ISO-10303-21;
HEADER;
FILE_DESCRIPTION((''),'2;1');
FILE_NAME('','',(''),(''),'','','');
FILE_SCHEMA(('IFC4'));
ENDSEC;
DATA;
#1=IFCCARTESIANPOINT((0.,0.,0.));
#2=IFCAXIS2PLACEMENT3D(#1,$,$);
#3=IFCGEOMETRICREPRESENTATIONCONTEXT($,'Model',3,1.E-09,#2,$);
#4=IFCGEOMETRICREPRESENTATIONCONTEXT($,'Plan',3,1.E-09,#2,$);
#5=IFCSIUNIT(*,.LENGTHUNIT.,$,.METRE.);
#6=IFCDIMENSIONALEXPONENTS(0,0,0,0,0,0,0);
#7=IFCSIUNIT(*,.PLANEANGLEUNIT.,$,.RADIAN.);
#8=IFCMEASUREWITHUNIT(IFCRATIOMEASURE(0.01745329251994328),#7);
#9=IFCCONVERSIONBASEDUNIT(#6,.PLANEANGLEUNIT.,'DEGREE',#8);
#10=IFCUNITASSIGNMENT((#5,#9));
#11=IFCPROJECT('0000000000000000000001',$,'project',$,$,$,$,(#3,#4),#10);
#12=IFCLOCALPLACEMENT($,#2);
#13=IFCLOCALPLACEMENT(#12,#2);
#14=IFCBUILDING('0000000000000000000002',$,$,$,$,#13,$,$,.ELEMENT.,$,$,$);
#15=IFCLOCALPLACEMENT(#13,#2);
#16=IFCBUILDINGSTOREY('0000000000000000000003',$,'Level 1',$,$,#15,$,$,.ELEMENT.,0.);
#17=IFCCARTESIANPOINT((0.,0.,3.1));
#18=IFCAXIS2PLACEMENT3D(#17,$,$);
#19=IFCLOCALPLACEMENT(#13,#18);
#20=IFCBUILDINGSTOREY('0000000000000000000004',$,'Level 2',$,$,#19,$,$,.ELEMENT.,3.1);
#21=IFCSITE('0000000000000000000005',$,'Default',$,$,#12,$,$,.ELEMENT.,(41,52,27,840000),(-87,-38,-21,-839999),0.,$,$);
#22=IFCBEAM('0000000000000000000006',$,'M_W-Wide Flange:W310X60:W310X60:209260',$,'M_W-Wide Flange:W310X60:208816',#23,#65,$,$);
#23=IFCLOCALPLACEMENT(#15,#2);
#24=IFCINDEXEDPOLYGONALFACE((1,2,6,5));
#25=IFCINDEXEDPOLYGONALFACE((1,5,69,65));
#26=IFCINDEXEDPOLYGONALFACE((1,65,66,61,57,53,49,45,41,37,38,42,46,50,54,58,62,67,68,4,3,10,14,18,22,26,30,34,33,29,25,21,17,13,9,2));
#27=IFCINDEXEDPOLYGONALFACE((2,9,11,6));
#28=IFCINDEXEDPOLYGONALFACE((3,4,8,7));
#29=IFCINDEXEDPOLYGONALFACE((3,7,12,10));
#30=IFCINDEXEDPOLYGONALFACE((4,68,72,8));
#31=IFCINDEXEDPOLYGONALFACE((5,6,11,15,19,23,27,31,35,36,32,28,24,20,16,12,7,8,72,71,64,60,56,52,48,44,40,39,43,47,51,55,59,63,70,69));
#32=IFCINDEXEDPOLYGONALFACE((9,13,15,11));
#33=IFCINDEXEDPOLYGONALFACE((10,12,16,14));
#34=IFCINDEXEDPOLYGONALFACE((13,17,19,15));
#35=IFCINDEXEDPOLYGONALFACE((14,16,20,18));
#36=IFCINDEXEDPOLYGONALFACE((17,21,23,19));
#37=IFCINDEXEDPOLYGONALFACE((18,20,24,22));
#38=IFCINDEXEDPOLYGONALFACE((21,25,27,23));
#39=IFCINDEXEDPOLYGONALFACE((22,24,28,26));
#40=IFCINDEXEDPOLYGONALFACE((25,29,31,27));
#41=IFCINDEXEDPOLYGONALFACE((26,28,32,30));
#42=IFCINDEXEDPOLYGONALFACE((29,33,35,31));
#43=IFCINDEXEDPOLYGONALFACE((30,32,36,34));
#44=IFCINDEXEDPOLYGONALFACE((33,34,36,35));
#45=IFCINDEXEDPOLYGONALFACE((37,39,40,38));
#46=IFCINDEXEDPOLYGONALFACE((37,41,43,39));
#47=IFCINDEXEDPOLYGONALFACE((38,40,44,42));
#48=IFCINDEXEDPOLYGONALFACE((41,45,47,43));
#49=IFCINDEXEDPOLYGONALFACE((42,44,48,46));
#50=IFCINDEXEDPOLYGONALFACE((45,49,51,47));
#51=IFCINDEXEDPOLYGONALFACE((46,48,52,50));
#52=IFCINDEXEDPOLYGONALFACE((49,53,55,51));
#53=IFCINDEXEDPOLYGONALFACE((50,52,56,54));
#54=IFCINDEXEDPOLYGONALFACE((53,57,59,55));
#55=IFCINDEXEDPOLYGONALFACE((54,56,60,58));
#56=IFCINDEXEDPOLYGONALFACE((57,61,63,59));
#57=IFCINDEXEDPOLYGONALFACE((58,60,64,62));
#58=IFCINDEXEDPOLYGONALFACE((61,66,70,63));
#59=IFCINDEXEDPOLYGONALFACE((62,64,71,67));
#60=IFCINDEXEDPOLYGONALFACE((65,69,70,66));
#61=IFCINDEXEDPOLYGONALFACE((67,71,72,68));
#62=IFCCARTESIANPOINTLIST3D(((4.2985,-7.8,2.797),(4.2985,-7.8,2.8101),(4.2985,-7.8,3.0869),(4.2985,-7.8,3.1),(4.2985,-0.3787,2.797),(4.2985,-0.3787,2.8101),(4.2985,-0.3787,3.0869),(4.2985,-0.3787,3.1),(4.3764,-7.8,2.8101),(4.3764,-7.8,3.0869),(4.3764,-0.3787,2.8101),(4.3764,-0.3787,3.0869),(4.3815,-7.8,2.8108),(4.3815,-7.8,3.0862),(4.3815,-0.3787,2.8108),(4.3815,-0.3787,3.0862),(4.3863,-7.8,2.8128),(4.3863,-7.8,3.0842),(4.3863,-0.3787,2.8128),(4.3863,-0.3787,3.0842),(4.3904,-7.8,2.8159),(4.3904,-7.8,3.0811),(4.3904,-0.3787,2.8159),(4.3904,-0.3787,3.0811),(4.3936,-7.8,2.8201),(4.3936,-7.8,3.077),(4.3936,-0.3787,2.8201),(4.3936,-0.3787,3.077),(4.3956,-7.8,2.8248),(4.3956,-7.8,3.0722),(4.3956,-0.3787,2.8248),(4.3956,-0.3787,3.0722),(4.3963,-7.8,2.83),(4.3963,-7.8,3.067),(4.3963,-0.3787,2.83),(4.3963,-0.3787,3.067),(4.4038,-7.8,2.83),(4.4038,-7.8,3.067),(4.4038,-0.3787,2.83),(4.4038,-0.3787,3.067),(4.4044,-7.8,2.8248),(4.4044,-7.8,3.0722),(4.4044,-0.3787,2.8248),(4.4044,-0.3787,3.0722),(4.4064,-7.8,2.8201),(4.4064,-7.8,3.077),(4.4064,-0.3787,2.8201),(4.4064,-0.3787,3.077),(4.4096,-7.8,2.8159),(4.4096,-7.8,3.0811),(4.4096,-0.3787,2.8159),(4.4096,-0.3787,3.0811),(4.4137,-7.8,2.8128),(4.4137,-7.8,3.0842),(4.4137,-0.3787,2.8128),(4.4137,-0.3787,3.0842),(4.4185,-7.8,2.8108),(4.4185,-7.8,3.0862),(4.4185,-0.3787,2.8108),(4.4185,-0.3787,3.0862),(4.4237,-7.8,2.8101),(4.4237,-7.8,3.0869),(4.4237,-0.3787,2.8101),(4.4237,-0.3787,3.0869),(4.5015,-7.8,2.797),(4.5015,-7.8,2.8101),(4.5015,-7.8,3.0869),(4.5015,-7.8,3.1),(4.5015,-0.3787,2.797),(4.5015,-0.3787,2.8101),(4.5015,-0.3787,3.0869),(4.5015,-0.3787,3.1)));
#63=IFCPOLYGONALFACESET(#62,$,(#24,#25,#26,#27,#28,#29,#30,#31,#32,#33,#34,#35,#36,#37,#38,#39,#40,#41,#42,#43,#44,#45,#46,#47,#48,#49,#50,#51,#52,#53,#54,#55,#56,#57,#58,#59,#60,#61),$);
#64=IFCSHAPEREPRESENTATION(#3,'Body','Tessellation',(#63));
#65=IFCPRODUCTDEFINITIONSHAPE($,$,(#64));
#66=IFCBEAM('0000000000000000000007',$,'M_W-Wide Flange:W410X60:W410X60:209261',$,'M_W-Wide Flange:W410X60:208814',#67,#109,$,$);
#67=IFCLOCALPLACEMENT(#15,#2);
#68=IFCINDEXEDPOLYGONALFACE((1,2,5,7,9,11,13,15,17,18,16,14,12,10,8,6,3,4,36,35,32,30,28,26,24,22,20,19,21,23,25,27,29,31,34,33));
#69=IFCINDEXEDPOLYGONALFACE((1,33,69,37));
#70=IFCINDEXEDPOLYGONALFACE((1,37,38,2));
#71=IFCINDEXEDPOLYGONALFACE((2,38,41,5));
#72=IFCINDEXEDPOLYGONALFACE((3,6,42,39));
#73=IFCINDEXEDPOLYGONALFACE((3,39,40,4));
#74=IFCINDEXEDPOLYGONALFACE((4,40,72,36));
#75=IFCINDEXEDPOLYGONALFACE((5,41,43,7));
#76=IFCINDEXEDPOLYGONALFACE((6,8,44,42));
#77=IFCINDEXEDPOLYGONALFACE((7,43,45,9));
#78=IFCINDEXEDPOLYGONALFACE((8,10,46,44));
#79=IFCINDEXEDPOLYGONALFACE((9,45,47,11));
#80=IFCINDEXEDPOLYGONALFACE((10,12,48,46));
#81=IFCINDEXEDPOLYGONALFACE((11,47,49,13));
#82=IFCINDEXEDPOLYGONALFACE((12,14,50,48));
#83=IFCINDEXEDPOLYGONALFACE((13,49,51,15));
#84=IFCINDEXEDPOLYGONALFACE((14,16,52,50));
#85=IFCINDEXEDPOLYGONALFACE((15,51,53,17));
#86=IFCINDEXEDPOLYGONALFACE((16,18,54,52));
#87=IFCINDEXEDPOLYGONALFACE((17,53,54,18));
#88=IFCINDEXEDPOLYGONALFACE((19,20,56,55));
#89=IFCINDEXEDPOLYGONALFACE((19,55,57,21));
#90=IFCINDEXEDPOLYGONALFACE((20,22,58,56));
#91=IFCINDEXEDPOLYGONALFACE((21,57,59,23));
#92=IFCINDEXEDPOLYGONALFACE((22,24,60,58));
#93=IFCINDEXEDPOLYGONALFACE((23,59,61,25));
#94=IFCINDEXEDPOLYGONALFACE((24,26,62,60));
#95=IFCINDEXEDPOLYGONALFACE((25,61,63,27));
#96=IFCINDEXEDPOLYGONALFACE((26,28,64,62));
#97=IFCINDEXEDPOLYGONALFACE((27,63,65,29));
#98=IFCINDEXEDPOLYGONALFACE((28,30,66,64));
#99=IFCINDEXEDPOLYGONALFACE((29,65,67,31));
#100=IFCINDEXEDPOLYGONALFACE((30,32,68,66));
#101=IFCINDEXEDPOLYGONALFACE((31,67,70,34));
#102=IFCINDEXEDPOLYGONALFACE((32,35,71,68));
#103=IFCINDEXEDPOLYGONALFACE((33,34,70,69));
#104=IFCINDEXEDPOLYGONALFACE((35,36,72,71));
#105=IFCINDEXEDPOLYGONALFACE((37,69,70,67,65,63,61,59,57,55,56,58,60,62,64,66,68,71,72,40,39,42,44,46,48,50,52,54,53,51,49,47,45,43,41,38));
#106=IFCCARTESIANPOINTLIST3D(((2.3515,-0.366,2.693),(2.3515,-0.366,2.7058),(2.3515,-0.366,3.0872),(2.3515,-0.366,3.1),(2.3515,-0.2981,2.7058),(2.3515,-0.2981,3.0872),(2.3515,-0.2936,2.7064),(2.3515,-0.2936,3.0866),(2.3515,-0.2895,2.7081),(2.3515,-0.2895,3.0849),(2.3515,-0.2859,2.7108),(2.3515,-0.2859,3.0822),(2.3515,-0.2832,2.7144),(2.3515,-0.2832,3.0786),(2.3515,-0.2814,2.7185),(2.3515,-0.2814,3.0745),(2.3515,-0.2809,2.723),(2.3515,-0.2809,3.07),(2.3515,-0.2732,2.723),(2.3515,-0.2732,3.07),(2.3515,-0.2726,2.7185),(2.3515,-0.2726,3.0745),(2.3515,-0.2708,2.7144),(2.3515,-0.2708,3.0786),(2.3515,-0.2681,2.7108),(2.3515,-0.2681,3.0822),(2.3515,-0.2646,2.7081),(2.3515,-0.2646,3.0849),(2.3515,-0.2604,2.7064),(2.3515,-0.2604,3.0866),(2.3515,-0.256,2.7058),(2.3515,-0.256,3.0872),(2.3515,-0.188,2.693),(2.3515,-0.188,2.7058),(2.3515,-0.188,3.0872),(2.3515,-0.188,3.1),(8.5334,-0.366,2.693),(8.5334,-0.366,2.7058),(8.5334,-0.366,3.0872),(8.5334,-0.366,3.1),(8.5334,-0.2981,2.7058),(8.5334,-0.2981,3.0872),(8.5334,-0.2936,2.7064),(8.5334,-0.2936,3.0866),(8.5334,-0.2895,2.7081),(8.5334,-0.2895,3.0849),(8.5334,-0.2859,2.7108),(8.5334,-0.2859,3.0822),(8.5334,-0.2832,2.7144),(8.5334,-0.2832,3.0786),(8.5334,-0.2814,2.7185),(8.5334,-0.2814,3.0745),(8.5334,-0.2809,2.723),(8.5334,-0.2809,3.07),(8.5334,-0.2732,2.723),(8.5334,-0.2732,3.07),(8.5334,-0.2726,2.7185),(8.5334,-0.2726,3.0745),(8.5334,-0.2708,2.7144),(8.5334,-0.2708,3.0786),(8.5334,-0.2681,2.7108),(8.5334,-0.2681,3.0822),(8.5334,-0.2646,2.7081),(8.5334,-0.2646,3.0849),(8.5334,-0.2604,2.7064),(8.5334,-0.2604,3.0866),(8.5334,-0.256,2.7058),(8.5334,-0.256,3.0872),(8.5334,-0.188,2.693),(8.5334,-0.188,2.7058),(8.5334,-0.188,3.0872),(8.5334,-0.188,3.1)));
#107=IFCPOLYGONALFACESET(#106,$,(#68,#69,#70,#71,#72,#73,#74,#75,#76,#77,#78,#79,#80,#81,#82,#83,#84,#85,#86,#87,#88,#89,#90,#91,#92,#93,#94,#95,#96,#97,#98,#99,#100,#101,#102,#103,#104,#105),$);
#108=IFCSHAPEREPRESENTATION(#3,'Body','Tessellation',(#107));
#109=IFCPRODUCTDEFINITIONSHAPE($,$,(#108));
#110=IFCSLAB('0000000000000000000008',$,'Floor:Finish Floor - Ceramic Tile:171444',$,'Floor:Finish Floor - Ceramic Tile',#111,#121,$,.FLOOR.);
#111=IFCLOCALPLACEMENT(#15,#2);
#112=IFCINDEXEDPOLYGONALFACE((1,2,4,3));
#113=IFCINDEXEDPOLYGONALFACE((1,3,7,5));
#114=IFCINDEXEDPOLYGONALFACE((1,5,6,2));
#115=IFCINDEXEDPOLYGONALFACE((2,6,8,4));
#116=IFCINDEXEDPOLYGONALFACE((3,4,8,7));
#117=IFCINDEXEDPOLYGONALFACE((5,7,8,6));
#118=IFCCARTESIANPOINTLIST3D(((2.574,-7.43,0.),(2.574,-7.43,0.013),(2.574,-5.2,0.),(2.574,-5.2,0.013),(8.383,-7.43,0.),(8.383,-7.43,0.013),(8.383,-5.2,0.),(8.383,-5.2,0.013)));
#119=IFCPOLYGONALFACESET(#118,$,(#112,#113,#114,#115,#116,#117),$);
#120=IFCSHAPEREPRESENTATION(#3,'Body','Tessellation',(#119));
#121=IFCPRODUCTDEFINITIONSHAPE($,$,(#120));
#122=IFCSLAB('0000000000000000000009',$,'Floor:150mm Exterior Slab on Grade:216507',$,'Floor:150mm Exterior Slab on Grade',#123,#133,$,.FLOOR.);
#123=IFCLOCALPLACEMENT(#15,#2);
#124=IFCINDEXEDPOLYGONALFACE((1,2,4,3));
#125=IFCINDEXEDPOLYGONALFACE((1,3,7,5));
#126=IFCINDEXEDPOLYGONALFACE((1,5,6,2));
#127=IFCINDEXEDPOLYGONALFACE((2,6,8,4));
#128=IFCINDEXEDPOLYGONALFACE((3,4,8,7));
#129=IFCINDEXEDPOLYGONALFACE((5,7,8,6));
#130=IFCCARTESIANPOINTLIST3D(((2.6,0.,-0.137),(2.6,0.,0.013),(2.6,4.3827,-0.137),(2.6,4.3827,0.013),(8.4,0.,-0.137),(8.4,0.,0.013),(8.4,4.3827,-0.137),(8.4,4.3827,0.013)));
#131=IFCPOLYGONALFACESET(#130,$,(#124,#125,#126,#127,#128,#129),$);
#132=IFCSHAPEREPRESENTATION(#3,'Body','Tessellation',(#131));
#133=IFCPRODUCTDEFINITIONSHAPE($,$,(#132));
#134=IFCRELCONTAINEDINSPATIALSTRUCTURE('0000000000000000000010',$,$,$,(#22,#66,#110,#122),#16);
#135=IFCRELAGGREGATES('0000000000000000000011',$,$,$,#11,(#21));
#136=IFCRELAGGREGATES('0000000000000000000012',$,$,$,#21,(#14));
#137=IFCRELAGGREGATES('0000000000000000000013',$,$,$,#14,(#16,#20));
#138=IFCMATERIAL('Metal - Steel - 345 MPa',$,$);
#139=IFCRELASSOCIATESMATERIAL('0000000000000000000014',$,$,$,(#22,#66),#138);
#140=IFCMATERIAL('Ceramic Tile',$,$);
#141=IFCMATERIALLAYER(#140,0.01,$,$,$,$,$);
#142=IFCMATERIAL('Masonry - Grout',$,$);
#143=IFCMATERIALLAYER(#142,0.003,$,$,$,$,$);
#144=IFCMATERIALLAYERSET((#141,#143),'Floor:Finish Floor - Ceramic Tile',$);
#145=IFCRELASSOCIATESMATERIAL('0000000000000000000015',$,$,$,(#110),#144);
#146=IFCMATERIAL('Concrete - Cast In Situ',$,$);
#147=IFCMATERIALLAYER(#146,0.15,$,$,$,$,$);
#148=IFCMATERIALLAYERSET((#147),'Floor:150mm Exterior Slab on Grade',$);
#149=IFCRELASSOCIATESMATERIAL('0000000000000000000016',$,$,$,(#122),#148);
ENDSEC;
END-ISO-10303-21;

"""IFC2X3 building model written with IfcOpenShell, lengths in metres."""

from ifc_helpers import new_model, entity, si_unit, converted_unit, frame, frame_2d, origin, place, context, project, spatial, polyline, circle_curve, parameter, trimmed, segment, composite_curve, rectangle, outline, extrude, material, layer, layer_set, layer_usage, element, save


model = new_model("IFC2X3")

# Units and contexts
model_context_1 = context("Model", 3, precision=1e-09, world=origin())
plan_context = context("Plan", 3, precision=1e-09, world=origin())
ifc_project = project(units=[si_unit("LENGTHUNIT", "METRE"), converted_unit("PLANEANGLEUNIT", "DEGREE", entity("IfcRatioMeasure", 0.01745329251994328), si_unit("PLANEANGLEUNIT", "RADIAN"), dimensions=[0, 0, 0, 0, 0, 0, 0])], contexts=[model_context_1, plan_context])

# Site, building, storey
site_placement = place(None, origin())
site = spatial("IfcSite", under=ifc_project, at=site_placement, Name="Default", CompositionType="ELEMENT", RefLatitude=(41, 52, 27, 840000), RefLongitude=(-87, -38, -21, -839999), RefElevation=0.0)
building_placement = place(site_placement, origin())
building = spatial("IfcBuilding", under=site, at=building_placement, CompositionType="ELEMENT")
storey_1_placement = place(building_placement, origin())
storey_1 = spatial("IfcBuildingStorey", under=building, at=storey_1_placement, Name="Level 1", CompositionType="ELEMENT", Elevation=0.0)

# Beams
ifc_material_1 = material(Name="Metal - Steel - 345 MPa")
beam_1_placement = place(storey_1_placement, frame((4.4, -7.8, 3.1)))
element("IfcBeam", 1, at=beam_1_placement, inside=storey_1, material=ifc_material_1, Name="M_W-Wide Flange:W310X60:W310X60:209260", ObjectType="M_W-Wide Flange:W310X60:208816", context=model_context_1, shape_type="SweptSolid", body=[
    extrude(outline(composite_curve([segment(polyline([(-0.1015, -0.1384), (-0.1015, -0.1515)]), True, "CONTINUOUS"), segment(polyline([(-0.1015, -0.1515), (0.1015, -0.1515)]), True, "CONTINUOUS"), segment(polyline([(0.1015, -0.1515), (0.1015, -0.1384)]), True, "CONTINUOUS"), segment(polyline([(0.1015, -0.1384), (0.0236, -0.1384)]), True, "CONTINUOUS"), segment(trimmed(circle_curve(frame_2d((0.0236, -0.1185), x_axis=(1.0, 0.0)), 0.0199), [parameter(180.0)], [parameter(270.0)], True, "PARAMETER"), False, "CONTINUOUS"), segment(polyline([(0.0037, -0.1185), (0.0037, 0.1185)]), True, "CONTINUOUS"), segment(trimmed(circle_curve(frame_2d((0.0236, 0.1185), x_axis=(1.0, 0.0)), 0.0199), [parameter(90.0)], [parameter(180.0)], True, "PARAMETER"), False, "CONTINUOUS"), segment(polyline([(0.0236, 0.1384), (0.1015, 0.1384)]), True, "CONTINUOUS"), segment(polyline([(0.1015, 0.1384), (0.1015, 0.1515)]), True, "CONTINUOUS"), segment(polyline([(0.1015, 0.1515), (-0.1015, 0.1515)]), True, "CONTINUOUS"), segment(polyline([(-0.1015, 0.1515), (-0.1015, 0.1384)]), True, "CONTINUOUS"), segment(polyline([(-0.1015, 0.1384), (-0.0237, 0.1384)]), True, "CONTINUOUS"), segment(trimmed(circle_curve(frame_2d((-0.0237, 0.1185), x_axis=(1.0, 0.0)), 0.0199), [parameter(360.0)], [parameter(90.0)], True, "PARAMETER"), False, "CONTINUOUS"), segment(polyline([(-0.0038, 0.1185), (-0.0038, -0.1185)]), True, "CONTINUOUS"), segment(trimmed(circle_curve(frame_2d((-0.0237, -0.1185), x_axis=(1.0, 0.0)), 0.0199), [parameter(270.0)], [parameter(0.0)], True, "PARAMETER"), False, "CONTINUOUS"), segment(polyline([(-0.0237, -0.1384), (-0.1015, -0.1384)]), True, "CONTINUOUS")], self_intersect=False)), frame((0.0, 0.0, -0.1515), z_axis=(0.0, -1.0, 0.0), x_axis=(1.0, 0.0, 0.0)), (0.0, 0.0, -1.0), 7.4213),
])
beam_2_placement = place(storey_1_placement, frame((8.5915, -0.277, 3.1), z_axis=(0.0, 0.0, 1.0), x_axis=(0.0, 1.0, 0.0)))
element("IfcBeam", 2, at=beam_2_placement, inside=storey_1, material=ifc_material_1, Name="M_W-Wide Flange:W410X60:W410X60:209261", ObjectType="M_W-Wide Flange:W410X60:208814", context=model_context_1, shape_type="SweptSolid", body=[
    extrude(outline(composite_curve([segment(polyline([(0.1907, -0.089), (0.2035, -0.089)]), True, "CONTINUOUS"), segment(polyline([(0.2035, -0.089), (0.2035, 0.089)]), True, "CONTINUOUS"), segment(polyline([(0.2035, 0.089), (0.1907, 0.089)]), True, "CONTINUOUS"), segment(polyline([(0.1907, 0.089), (0.1907, 0.021)]), True, "CONTINUOUS"), segment(trimmed(circle_curve(frame_2d((0.1735, 0.021), x_axis=(1.0, 0.0)), 0.0172), [parameter(270.0)], [parameter(360.0)], True, "PARAMETER"), False, "CONTINUOUS"), segment(polyline([(0.1735, 0.0038), (-0.1735, 0.0038)]), True, "CONTINUOUS"), segment(trimmed(circle_curve(frame_2d((-0.1735, 0.021), x_axis=(0.0, -1.0)), 0.0172), [parameter(270.0)], [parameter(360.0)], True, "PARAMETER"), False, "CONTINUOUS"), segment(polyline([(-0.1907, 0.021), (-0.1907, 0.089)]), True, "CONTINUOUS"), segment(polyline([(-0.1907, 0.089), (-0.2035, 0.089)]), True, "CONTINUOUS"), segment(polyline([(-0.2035, 0.089), (-0.2035, -0.089)]), True, "CONTINUOUS"), segment(polyline([(-0.2035, -0.089), (-0.1907, -0.089)]), True, "CONTINUOUS"), segment(polyline([(-0.1907, -0.089), (-0.1907, -0.0211)]), True, "CONTINUOUS"), segment(trimmed(circle_curve(frame_2d((-0.1735, -0.0211), x_axis=(-1.0, 0.0)), 0.0172), [parameter(270.0)], [parameter(0.0)], True, "PARAMETER"), False, "CONTINUOUS"), segment(polyline([(-0.1735, -0.0039), (0.1735, -0.0039)]), True, "CONTINUOUS"), segment(trimmed(circle_curve(frame_2d((0.1735, -0.0211), x_axis=(0.0, 1.0)), 0.0172), [parameter(270.0)], [parameter(0.0)], True, "PARAMETER"), False, "CONTINUOUS"), segment(polyline([(0.1907, -0.0211), (0.1907, -0.089)]), True, "CONTINUOUS")], self_intersect=False)), frame((0.0, 6.24, -0.2035), z_axis=(0.0, -1.0, 0.0), x_axis=(0.0, 0.0, -1.0)), (0.0, 0.0, 1.0), 6.1819),
])

# Slabs
ifc_material_2 = material(Name="Ceramic Tile")
ifc_layer_1 = layer(ifc_material_2, 0.01)
ifc_material_3 = material(Name="Masonry - Grout")
ifc_layer_2 = layer(ifc_material_3, 0.003)
ifc_layer_set_1 = layer_set([ifc_layer_1, ifc_layer_2], Name="Floor:Finish Floor - Ceramic Tile")
ifc_layer_usage_1 = layer_usage(ifc_layer_set_1, "AXIS3", "POSITIVE", 0.0)
slab_1_placement = place(storey_1_placement, frame((2.574, -7.43, 0.0)))
element("IfcSlab", 3, at=slab_1_placement, inside=storey_1, material=ifc_layer_usage_1, Name="Floor:Finish Floor - Ceramic Tile:171444", ObjectType="Floor:Finish Floor - Ceramic Tile", PredefinedType="FLOOR", context=model_context_1, shape_type="SweptSolid", body=[
    extrude(rectangle(XDim=5.809, YDim=2.23, at=frame_2d((0.0, 0.0), x_axis=(-1.0, 0.0))), frame((2.9045, 1.115, 0.013), z_axis=(0.0, 0.0, -1.0), x_axis=(-1.0, 0.0, 0.0)), (0.0, 0.0, 1.0), 0.013),
])
ifc_material_4 = material(Name="Concrete - Cast In Situ")
ifc_layer_3 = layer(ifc_material_4, 0.15)
ifc_layer_set_2 = layer_set([ifc_layer_3], Name="Floor:150mm Exterior Slab on Grade")
ifc_layer_usage_2 = layer_usage(ifc_layer_set_2, "AXIS3", "POSITIVE", 0.0)
slab_2_placement = place(storey_1_placement, frame((2.6, 0.0, -0.137)))
element("IfcSlab", 4, at=slab_2_placement, inside=storey_1, material=ifc_layer_usage_2, Name="Floor:150mm Exterior Slab on Grade:216507", ObjectType="Floor:150mm Exterior Slab on Grade", PredefinedType="FLOOR", context=model_context_1, shape_type="SweptSolid", body=[
    extrude(rectangle(XDim=5.8, YDim=4.3827, at=frame_2d((0.0, 0.0), x_axis=(-1.0, 0.0))), frame((2.9, 2.1914, 0.15), z_axis=(0.0, 0.0, -1.0), x_axis=(-1.0, 0.0, 0.0)), (0.0, 0.0, 1.0), 0.15),
])

# Shared definitions
storey_2_placement = place(building_placement, frame((0.0, 0.0, 3.1)))
storey_2 = spatial("IfcBuildingStorey", under=building, at=storey_2_placement, Name="Level 2", CompositionType="ELEMENT", Elevation=3.1)

save(model, "model.ifc")
